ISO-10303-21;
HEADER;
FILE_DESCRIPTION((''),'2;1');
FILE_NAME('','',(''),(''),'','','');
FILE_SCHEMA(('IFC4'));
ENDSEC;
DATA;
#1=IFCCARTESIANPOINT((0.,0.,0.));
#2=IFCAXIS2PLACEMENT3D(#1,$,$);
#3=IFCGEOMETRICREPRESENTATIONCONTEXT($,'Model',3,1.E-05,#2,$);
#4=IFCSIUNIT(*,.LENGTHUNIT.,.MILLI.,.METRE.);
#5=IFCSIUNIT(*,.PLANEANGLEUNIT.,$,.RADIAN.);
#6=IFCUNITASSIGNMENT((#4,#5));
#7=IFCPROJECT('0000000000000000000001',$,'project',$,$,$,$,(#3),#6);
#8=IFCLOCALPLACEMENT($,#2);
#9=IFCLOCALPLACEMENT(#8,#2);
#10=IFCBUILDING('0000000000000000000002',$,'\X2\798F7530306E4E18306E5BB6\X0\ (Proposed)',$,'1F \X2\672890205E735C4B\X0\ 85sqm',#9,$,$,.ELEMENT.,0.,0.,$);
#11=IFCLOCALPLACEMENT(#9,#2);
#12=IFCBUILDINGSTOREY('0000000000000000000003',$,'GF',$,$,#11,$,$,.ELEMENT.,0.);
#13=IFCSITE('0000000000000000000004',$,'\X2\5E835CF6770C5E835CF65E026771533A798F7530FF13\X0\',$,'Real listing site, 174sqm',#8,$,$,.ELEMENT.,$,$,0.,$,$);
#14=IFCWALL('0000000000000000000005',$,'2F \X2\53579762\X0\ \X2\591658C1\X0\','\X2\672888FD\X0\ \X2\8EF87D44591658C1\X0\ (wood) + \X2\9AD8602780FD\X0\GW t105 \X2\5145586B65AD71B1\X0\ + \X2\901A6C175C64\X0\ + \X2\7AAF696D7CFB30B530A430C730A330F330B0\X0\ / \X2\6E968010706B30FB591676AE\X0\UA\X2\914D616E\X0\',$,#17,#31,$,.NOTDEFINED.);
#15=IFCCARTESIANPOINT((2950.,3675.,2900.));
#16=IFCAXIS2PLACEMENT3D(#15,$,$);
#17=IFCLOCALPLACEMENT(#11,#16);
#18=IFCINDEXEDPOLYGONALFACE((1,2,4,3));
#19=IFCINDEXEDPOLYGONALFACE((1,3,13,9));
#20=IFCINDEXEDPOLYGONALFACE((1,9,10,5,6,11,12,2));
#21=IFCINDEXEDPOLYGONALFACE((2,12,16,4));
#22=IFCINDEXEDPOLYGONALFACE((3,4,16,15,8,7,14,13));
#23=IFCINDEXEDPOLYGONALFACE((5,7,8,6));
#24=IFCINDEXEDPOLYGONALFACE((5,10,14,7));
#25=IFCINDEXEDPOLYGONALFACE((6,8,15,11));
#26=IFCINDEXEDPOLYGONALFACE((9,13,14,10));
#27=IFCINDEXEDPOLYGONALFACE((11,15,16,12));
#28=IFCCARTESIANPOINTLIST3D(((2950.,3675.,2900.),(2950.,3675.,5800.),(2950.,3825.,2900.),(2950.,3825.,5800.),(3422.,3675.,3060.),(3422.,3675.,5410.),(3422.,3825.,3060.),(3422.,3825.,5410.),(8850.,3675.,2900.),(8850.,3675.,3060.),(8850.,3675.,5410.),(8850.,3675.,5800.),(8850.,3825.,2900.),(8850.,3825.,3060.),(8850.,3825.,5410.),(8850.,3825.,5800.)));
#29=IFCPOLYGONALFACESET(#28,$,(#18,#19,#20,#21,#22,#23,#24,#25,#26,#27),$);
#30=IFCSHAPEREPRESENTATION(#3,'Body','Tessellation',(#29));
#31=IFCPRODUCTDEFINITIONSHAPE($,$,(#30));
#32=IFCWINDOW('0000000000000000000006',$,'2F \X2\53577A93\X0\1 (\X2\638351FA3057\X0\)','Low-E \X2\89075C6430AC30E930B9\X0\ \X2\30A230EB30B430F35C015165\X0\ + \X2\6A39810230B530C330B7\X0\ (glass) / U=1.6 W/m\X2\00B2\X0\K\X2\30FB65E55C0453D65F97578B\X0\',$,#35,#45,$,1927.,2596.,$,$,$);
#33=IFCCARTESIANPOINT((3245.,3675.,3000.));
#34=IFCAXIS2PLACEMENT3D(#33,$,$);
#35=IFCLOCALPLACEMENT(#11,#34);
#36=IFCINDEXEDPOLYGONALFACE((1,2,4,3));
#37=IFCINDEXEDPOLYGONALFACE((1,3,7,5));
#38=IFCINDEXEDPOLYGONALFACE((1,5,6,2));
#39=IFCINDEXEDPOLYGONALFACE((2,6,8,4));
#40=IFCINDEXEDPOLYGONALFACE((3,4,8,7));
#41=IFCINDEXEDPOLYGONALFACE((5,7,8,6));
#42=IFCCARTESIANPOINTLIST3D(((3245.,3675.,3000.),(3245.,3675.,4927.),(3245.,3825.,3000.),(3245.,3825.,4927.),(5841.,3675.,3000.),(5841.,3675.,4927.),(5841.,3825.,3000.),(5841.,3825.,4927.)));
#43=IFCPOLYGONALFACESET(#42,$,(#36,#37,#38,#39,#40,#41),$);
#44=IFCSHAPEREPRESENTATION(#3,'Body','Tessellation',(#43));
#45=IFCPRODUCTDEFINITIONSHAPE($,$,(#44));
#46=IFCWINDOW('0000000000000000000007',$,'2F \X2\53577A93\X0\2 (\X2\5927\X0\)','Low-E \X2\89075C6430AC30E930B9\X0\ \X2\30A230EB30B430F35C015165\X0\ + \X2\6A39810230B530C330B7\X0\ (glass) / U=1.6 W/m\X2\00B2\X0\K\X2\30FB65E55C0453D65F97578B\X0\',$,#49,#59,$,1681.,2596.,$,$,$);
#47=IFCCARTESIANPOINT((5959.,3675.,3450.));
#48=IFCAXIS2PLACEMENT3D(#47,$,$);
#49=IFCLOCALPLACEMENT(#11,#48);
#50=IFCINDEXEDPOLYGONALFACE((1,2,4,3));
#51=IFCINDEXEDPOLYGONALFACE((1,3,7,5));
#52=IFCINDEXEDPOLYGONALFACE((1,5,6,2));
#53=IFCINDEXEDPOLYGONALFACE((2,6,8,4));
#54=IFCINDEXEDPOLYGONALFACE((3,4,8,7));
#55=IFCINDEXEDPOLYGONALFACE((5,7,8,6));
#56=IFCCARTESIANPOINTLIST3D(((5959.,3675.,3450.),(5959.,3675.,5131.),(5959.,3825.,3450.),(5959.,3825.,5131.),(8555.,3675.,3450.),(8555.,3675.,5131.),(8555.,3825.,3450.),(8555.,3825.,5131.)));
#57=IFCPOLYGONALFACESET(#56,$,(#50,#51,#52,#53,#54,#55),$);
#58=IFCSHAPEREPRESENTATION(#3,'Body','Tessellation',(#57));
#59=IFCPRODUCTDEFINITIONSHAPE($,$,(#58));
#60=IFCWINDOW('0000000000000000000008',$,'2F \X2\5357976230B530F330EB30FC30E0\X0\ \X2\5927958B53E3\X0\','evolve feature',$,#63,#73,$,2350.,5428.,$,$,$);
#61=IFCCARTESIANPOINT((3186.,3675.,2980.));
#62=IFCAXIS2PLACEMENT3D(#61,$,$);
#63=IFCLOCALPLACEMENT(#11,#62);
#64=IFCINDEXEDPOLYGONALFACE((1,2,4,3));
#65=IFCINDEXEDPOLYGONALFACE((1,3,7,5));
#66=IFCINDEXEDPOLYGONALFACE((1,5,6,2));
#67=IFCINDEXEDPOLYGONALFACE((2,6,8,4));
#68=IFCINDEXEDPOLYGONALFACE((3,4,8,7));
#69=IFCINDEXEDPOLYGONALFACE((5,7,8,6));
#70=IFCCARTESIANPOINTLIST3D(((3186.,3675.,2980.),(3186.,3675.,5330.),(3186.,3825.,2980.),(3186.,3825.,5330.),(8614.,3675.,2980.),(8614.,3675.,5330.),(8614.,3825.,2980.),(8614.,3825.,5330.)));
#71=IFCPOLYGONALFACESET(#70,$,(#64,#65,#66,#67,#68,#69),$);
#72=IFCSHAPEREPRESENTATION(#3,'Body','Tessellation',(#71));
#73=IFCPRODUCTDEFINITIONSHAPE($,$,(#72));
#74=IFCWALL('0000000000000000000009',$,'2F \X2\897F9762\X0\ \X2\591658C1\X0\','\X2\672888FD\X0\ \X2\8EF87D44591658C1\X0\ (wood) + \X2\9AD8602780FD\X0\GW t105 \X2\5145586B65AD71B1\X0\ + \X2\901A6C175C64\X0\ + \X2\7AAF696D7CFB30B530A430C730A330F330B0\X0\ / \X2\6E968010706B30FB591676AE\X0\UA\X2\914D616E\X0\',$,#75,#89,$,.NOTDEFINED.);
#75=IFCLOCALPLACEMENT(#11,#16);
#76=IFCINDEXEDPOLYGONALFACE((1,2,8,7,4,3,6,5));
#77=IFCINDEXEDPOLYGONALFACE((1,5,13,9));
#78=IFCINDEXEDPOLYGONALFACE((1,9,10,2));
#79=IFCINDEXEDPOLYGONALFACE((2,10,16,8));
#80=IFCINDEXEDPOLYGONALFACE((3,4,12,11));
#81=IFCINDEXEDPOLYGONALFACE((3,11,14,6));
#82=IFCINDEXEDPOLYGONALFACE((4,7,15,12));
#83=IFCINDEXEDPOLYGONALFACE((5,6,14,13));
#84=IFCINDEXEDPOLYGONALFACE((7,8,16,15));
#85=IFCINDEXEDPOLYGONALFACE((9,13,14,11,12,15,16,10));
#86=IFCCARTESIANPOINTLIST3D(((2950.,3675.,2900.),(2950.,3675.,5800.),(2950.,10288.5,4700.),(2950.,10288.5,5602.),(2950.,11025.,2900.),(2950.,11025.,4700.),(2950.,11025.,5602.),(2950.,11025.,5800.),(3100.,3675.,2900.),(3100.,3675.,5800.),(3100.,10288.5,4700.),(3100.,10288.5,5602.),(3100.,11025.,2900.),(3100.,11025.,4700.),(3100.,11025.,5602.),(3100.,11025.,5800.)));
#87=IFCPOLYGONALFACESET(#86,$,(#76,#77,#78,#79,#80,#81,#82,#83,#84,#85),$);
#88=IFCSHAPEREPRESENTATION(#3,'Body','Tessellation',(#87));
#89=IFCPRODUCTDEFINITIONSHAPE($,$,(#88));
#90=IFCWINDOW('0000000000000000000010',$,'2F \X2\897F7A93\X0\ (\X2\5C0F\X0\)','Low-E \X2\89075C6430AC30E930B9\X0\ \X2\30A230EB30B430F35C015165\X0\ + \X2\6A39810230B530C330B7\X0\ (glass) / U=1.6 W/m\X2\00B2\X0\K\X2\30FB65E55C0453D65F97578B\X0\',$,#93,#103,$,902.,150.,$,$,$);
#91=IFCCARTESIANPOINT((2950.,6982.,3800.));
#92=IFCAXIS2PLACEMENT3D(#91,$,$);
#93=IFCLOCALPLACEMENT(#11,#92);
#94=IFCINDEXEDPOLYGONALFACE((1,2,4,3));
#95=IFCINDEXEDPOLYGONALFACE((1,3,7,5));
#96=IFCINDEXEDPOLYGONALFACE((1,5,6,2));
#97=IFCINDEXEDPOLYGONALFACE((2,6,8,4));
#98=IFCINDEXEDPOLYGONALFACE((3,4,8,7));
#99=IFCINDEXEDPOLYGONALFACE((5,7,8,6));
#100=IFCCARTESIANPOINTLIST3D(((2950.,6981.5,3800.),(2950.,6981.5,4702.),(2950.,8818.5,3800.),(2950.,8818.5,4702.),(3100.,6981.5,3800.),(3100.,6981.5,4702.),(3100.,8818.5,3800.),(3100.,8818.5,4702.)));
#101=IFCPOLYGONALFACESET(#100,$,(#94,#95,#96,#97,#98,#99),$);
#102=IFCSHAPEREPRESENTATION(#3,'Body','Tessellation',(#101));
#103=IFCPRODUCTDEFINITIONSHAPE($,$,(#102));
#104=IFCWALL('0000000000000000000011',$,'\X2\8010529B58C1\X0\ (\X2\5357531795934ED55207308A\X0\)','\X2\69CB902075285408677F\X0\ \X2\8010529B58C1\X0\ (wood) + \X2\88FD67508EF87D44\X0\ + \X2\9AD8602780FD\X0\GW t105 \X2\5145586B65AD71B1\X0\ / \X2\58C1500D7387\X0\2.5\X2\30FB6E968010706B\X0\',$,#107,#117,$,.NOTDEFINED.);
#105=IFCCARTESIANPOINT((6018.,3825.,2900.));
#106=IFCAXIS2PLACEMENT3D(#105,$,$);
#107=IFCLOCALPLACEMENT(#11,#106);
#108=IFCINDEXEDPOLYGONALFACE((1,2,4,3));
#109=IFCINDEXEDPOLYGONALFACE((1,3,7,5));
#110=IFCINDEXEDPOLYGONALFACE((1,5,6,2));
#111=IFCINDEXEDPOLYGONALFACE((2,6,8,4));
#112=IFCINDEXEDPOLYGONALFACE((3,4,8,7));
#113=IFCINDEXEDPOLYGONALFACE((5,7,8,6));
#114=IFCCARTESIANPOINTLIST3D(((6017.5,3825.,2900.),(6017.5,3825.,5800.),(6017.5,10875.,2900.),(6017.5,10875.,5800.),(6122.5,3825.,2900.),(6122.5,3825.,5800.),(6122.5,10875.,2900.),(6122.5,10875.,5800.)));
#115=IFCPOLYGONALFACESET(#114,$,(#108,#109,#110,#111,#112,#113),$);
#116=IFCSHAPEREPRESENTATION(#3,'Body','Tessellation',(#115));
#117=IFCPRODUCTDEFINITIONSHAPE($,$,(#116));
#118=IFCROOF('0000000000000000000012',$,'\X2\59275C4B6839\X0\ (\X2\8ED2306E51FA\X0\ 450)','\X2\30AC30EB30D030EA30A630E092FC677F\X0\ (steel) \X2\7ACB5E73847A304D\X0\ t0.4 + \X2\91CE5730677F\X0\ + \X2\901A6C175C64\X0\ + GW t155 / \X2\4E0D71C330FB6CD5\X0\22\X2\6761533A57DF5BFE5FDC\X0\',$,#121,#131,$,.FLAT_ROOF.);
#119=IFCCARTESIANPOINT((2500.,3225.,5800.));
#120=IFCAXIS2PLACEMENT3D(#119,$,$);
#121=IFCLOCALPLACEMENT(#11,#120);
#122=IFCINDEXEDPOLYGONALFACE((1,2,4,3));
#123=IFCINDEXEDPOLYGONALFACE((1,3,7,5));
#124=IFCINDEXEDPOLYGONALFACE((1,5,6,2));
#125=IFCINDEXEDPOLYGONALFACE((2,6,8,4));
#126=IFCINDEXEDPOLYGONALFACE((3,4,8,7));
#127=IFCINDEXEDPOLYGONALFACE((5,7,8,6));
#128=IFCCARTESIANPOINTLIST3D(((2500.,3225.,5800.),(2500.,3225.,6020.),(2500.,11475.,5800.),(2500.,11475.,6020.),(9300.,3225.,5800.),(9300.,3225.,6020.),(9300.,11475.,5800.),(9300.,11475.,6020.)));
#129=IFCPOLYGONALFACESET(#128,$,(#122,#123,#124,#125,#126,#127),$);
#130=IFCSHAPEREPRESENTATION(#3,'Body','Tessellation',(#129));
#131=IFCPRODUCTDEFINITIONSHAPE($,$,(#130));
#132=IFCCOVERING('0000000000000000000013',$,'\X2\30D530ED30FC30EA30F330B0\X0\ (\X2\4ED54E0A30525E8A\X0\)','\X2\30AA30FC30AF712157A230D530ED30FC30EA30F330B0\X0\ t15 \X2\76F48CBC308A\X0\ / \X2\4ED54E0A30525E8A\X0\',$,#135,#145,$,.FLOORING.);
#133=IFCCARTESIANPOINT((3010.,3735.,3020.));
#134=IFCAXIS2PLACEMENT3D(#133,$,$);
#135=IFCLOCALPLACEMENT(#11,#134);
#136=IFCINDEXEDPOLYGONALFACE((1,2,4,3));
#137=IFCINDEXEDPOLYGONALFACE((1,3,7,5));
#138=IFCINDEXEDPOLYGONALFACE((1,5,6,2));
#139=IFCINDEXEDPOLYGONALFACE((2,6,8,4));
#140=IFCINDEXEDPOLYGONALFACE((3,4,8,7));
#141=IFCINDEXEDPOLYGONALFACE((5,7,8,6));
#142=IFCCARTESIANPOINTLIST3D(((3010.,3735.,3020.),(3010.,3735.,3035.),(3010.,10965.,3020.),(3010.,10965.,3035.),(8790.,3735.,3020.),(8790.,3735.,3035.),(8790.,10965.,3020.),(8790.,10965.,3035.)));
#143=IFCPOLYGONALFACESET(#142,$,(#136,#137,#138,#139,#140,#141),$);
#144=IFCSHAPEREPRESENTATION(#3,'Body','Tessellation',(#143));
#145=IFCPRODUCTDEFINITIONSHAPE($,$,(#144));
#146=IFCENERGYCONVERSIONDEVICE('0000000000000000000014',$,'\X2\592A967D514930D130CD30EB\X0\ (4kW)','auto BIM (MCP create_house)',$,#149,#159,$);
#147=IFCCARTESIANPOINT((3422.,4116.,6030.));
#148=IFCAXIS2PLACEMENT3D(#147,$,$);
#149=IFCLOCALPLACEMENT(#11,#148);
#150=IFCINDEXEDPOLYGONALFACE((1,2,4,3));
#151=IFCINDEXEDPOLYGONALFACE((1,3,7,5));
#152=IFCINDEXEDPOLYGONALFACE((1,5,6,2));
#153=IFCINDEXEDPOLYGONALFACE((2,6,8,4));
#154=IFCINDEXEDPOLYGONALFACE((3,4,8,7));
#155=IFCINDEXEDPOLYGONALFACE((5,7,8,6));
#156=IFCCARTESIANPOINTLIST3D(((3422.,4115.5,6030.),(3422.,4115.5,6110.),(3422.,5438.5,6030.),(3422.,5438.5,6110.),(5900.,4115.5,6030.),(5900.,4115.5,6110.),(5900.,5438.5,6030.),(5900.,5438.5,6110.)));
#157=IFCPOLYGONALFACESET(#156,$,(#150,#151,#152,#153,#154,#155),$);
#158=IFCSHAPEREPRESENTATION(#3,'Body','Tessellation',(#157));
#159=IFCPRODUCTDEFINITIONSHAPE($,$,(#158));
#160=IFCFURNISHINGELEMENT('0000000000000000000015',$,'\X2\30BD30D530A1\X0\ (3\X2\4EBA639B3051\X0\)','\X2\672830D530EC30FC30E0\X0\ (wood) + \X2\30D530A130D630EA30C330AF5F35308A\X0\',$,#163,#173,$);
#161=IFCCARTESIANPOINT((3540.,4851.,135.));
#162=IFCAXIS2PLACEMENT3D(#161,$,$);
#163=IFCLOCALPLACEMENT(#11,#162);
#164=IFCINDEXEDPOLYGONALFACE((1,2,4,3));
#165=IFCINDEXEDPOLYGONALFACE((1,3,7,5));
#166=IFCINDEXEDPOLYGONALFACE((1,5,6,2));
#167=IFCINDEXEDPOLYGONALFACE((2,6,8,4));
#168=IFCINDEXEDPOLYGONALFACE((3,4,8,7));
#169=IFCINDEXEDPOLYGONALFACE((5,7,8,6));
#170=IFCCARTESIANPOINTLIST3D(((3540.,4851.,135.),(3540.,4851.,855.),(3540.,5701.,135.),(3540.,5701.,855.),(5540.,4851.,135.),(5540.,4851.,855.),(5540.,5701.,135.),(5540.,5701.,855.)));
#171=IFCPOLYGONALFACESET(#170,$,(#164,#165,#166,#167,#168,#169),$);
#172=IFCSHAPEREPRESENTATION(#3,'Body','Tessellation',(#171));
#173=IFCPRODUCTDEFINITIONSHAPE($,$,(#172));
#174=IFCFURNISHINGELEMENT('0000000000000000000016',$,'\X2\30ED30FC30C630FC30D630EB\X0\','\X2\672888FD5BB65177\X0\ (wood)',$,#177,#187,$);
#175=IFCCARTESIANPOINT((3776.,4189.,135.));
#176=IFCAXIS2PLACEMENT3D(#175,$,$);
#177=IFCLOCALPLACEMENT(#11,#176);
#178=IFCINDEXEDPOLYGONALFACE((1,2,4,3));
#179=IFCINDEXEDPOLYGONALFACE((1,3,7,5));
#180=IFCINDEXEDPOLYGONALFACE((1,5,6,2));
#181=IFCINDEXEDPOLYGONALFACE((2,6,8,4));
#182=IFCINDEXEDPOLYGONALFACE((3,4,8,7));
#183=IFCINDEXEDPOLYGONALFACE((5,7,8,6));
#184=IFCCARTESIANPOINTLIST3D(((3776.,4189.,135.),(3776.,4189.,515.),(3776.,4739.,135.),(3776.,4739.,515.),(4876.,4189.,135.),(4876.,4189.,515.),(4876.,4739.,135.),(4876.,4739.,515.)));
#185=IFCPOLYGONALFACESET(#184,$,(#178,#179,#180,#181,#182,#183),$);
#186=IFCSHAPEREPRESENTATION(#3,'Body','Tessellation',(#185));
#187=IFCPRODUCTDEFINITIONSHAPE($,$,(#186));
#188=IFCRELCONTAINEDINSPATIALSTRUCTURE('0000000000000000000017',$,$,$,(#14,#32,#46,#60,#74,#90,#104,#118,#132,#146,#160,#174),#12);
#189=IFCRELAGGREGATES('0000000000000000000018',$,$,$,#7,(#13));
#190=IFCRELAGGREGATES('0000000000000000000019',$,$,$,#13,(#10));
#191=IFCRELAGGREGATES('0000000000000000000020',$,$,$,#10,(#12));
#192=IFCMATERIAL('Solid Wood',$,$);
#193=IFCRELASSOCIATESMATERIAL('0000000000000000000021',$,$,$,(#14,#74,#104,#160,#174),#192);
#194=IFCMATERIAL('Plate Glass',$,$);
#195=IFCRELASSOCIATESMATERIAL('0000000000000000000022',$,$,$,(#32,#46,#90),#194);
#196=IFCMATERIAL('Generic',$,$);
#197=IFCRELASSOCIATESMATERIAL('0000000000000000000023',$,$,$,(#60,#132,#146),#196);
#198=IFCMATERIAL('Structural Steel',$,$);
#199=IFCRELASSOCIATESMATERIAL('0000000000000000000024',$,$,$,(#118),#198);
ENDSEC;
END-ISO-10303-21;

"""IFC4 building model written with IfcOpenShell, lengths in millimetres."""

from ifc_helpers import new_model, si_unit, frame, frame_2d, origin, place, context, project, spatial, rectangle, extrude, material, element, fill, save


model = new_model("IFC4")

# Units and contexts
model_context = context("Model", 3, precision=1e-05, world=origin())
ifc_project = project(units=[si_unit("LENGTHUNIT", "METRE", prefix="MILLI"), si_unit("PLANEANGLEUNIT", "RADIAN")], contexts=[model_context])

# Site, building, storey
site_placement = place(None, origin())
site = spatial("IfcSite", under=ifc_project, at=site_placement, Name="広島県広島市東区福田３", ObjectType="Real listing site, 174sqm", CompositionType="ELEMENT", RefElevation=0.0)
building_placement = place(site_placement, origin())
building = spatial("IfcBuilding", under=site, at=building_placement, Name="福田の丘の家 (Proposed)", ObjectType="1F 木造平屋 85sqm", CompositionType="ELEMENT", ElevationOfRefHeight=0.0, ElevationOfTerrain=0.0)
storey_placement = place(building_placement, origin())
storey = spatial("IfcBuildingStorey", under=building, at=storey_placement, Name="GF", CompositionType="ELEMENT", Elevation=0.0)

# Shared definitions
ifc_material_1 = material(Name="Solid Wood")

# Wall, openings, windows
wall_1_placement = place(storey_placement, frame((2950.0, 3675.0, 2900.0)))
wall_1 = element("IfcWall", 1, at=wall_1_placement, inside=storey, material=ifc_material_1, Name="2F 南面 外壁", Description="木製 軸組外壁 (wood) + 高性能GW t105 充填断熱 + 通気層 + 窯業系サイディング / 準耐火・外皮UA配慮", PredefinedType="NOTDEFINED", context=model_context, shape_type="SweptSolid", body=[
    extrude(rectangle(XDim=5900.0, YDim=150.0, at=frame_2d((2950.0, 75.0))), frame((2950.0, 3675.0, 2900.0)), (0.0, 0.0, 1.0), 2900.0),
])
opening_1_placement = place(storey_placement, frame((3245.0, 3675.0, 3000.0)))
opening_1 = element("IfcOpeningElement", 2, at=opening_1_placement, cuts=wall_1, PredefinedType="NOTDEFINED", context=model_context, shape_type="SweptSolid", body=[
    extrude(rectangle(XDim=2596.0, YDim=150.0, at=frame_2d((1298.0, 75.0))), frame((3245.0, 3675.0, 3000.0)), (0.0, 0.0, 1.0), 1927.0),
])
opening_2_placement = place(storey_placement, frame((5959.0, 3675.0, 3450.0)))
opening_2 = element("IfcOpeningElement", 3, at=opening_2_placement, cuts=wall_1, PredefinedType="NOTDEFINED", context=model_context, shape_type="SweptSolid", body=[
    extrude(rectangle(XDim=2596.0, YDim=150.0, at=frame_2d((1298.0, 75.0))), frame((5959.0, 3675.0, 3450.0)), (0.0, 0.0, 1.0), 1681.0),
])
opening_3_placement = place(storey_placement, frame((3186.0, 3675.0, 2980.0)))
opening_3 = element("IfcOpeningElement", 4, at=opening_3_placement, cuts=wall_1, PredefinedType="NOTDEFINED", context=model_context, shape_type="SweptSolid", body=[
    extrude(rectangle(XDim=5428.0, YDim=150.0, at=frame_2d((2714.0, 75.0))), frame((3186.0, 3675.0, 2980.0)), (0.0, 0.0, 1.0), 2350.0),
])
ifc_material_2 = material(Name="Plate Glass")
window_1_placement = place(storey_placement, frame((3245.0, 3675.0, 3000.0)))
window_1 = element("IfcWindow", 5, at=window_1_placement, inside=storey, material=ifc_material_2, Name="2F 南窓1 (掃出し)", Description="Low-E 複層ガラス アルゴン封入 + 樹脂サッシ (glass) / U=1.6 W/m²K・日射取得型", OverallHeight=1927.0, OverallWidth=2596.0, context=model_context, shape_type="SweptSolid", body=[
    extrude(rectangle(XDim=2596.0, YDim=150.0, at=frame_2d((1298.0, 75.0))), frame((3245.0, 3675.0, 3000.0)), (0.0, 0.0, 1.0), 1927.0),
])
fill(opening_1, window_1)
window_2_placement = place(storey_placement, frame((5959.0, 3675.0, 3450.0)))
window_2 = element("IfcWindow", 6, at=window_2_placement, inside=storey, material=ifc_material_2, Name="2F 南窓2 (大)", Description="Low-E 複層ガラス アルゴン封入 + 樹脂サッシ (glass) / U=1.6 W/m²K・日射取得型", OverallHeight=1681.0, OverallWidth=2596.0, context=model_context, shape_type="SweptSolid", body=[
    extrude(rectangle(XDim=2596.0, YDim=150.0, at=frame_2d((1298.0, 75.0))), frame((5959.0, 3675.0, 3450.0)), (0.0, 0.0, 1.0), 1681.0),
])
fill(opening_2, window_2)
ifc_material_3 = material(Name="Generic")
window_3_placement = place(storey_placement, frame((3186.0, 3675.0, 2980.0)))
window_3 = element("IfcWindow", 7, at=window_3_placement, inside=storey, material=ifc_material_3, Name="2F 南面サンルーム 大開口", Description="evolve feature", OverallHeight=2350.0, OverallWidth=5428.0, context=model_context, shape_type="SweptSolid", body=[
    extrude(rectangle(XDim=5428.0, YDim=150.0, at=frame_2d((2714.0, 75.0))), frame((3186.0, 3675.0, 2980.0)), (0.0, 0.0, 1.0), 2350.0),
])
fill(opening_3, window_3)

# Wall, opening, window
wall_2_placement = place(storey_placement, frame((2950.0, 3675.0, 2900.0)))
wall_2 = element("IfcWall", 8, at=wall_2_placement, inside=storey, material=ifc_material_1, Name="2F 西面 外壁", Description="木製 軸組外壁 (wood) + 高性能GW t105 充填断熱 + 通気層 + 窯業系サイディング / 準耐火・外皮UA配慮", PredefinedType="NOTDEFINED", context=model_context, shape_type="SweptSolid", body=[
    extrude(rectangle(XDim=150.0, YDim=7350.0, at=frame_2d((75.0, 3675.0))), frame((2950.0, 3675.0, 2900.0)), (0.0, 0.0, 1.0), 2900.0),
])
opening_4_placement = place(storey_placement, frame((2950.0, 6982.0, 3800.0)))
opening_4 = element("IfcOpeningElement", 9, at=opening_4_placement, cuts=wall_2, PredefinedType="NOTDEFINED", context=model_context, shape_type="SweptSolid", body=[
    extrude(rectangle(XDim=150.0, YDim=1837.0, at=frame_2d((75.0, 918.0))), frame((2950.0, 6982.0, 3800.0)), (0.0, 0.0, 1.0), 902.0),
])
window_4_placement = place(storey_placement, frame((2950.0, 6982.0, 3800.0)))
window_4 = element("IfcWindow", 10, at=window_4_placement, inside=storey, material=ifc_material_2, Name="2F 西窓 (小)", Description="Low-E 複層ガラス アルゴン封入 + 樹脂サッシ (glass) / U=1.6 W/m²K・日射取得型", OverallHeight=902.0, OverallWidth=150.0, context=model_context, shape_type="SweptSolid", body=[
    extrude(rectangle(XDim=150.0, YDim=1837.0, at=frame_2d((75.0, 918.0))), frame((2950.0, 6982.0, 3800.0)), (0.0, 0.0, 1.0), 902.0),
])
fill(opening_4, window_4)

# Wall
wall_3_placement = place(storey_placement, frame((6018.0, 3825.0, 2900.0)))
element("IfcWall", 11, at=wall_3_placement, inside=storey, material=ifc_material_1, Name="耐力壁 (南北間仕切り)", Description="構造用合板 耐力壁 (wood) + 製材軸組 + 高性能GW t105 充填断熱 / 壁倍率2.5・準耐火", PredefinedType="NOTDEFINED", context=model_context, shape_type="SweptSolid", body=[
    extrude(rectangle(XDim=105.0, YDim=7050.0, at=frame_2d((52.0, 3525.0))), frame((6018.0, 3825.0, 2900.0)), (0.0, 0.0, 1.0), 2900.0),
])

# Roof
ifc_material_4 = material(Name="Structural Steel")
roof_placement = place(storey_placement, frame((2500.0, 3225.0, 5800.0)))
element("IfcRoof", 12, at=roof_placement, inside=storey, material=ifc_material_4, Name="大屋根 (軒の出 450)", Description="ガルバリウム鋼板 (steel) 立平葺き t0.4 + 野地板 + 通気層 + GW t155 / 不燃・法22条区域対応", PredefinedType="FLAT_ROOF", context=model_context, shape_type="SweptSolid", body=[
    extrude(rectangle(XDim=6800.0, YDim=8250.0, at=frame_2d((3400.0, 4125.0))), frame((2500.0, 3225.0, 5800.0)), (0.0, 0.0, 1.0), 220.0),
])

# Covering
covering_placement = place(storey_placement, frame((3010.0, 3735.0, 3020.0)))
element("IfcCovering", 13, at=covering_placement, inside=storey, material=ifc_material_3, Name="フローリング (仕上げ床)", Description="オーク無垢フローリング t15 直貼り / 仕上げ床", PredefinedType="FLOORING", context=model_context, shape_type="SweptSolid", body=[
    extrude(rectangle(XDim=5780.0, YDim=7230.0, at=frame_2d((2890.0, 3615.0))), frame((3010.0, 3735.0, 3020.0)), (0.0, 0.0, 1.0), 15.0),
])

# Energy conversion device
energy_conversion_device_placement = place(storey_placement, frame((3422.0, 4116.0, 6030.0)))
element("IfcEnergyConversionDevice", 14, at=energy_conversion_device_placement, inside=storey, material=ifc_material_3, Name="太陽光パネル (4kW)", Description="auto BIM (MCP create_house)", context=model_context, shape_type="SweptSolid", body=[
    extrude(rectangle(XDim=2478.0, YDim=1323.0, at=frame_2d((1239.0, 661.0))), frame((3422.0, 4116.0, 6030.0)), (0.0, 0.0, 1.0), 80.0),
])

# Furnishing elements
furnishing_1_placement = place(storey_placement, frame((3540.0, 4851.0, 135.0)))
element("IfcFurnishingElement", 15, at=furnishing_1_placement, inside=storey, material=ifc_material_1, Name="ソファ (3人掛け)", Description="木フレーム (wood) + ファブリック張り", context=model_context, shape_type="SweptSolid", body=[
    extrude(rectangle(XDim=2000.0, YDim=850.0, at=frame_2d((1000.0, 425.0))), frame((3540.0, 4851.0, 135.0)), (0.0, 0.0, 1.0), 720.0),
])
furnishing_2_placement = place(storey_placement, frame((3776.0, 4189.0, 135.0)))
element("IfcFurnishingElement", 16, at=furnishing_2_placement, inside=storey, material=ifc_material_1, Name="ローテーブル", Description="木製家具 (wood)", context=model_context, shape_type="SweptSolid", body=[
    extrude(rectangle(XDim=1100.0, YDim=550.0, at=frame_2d((550.0, 275.0))), frame((3776.0, 4189.0, 135.0)), (0.0, 0.0, 1.0), 380.0),
])

save(model, "model.ifc")
